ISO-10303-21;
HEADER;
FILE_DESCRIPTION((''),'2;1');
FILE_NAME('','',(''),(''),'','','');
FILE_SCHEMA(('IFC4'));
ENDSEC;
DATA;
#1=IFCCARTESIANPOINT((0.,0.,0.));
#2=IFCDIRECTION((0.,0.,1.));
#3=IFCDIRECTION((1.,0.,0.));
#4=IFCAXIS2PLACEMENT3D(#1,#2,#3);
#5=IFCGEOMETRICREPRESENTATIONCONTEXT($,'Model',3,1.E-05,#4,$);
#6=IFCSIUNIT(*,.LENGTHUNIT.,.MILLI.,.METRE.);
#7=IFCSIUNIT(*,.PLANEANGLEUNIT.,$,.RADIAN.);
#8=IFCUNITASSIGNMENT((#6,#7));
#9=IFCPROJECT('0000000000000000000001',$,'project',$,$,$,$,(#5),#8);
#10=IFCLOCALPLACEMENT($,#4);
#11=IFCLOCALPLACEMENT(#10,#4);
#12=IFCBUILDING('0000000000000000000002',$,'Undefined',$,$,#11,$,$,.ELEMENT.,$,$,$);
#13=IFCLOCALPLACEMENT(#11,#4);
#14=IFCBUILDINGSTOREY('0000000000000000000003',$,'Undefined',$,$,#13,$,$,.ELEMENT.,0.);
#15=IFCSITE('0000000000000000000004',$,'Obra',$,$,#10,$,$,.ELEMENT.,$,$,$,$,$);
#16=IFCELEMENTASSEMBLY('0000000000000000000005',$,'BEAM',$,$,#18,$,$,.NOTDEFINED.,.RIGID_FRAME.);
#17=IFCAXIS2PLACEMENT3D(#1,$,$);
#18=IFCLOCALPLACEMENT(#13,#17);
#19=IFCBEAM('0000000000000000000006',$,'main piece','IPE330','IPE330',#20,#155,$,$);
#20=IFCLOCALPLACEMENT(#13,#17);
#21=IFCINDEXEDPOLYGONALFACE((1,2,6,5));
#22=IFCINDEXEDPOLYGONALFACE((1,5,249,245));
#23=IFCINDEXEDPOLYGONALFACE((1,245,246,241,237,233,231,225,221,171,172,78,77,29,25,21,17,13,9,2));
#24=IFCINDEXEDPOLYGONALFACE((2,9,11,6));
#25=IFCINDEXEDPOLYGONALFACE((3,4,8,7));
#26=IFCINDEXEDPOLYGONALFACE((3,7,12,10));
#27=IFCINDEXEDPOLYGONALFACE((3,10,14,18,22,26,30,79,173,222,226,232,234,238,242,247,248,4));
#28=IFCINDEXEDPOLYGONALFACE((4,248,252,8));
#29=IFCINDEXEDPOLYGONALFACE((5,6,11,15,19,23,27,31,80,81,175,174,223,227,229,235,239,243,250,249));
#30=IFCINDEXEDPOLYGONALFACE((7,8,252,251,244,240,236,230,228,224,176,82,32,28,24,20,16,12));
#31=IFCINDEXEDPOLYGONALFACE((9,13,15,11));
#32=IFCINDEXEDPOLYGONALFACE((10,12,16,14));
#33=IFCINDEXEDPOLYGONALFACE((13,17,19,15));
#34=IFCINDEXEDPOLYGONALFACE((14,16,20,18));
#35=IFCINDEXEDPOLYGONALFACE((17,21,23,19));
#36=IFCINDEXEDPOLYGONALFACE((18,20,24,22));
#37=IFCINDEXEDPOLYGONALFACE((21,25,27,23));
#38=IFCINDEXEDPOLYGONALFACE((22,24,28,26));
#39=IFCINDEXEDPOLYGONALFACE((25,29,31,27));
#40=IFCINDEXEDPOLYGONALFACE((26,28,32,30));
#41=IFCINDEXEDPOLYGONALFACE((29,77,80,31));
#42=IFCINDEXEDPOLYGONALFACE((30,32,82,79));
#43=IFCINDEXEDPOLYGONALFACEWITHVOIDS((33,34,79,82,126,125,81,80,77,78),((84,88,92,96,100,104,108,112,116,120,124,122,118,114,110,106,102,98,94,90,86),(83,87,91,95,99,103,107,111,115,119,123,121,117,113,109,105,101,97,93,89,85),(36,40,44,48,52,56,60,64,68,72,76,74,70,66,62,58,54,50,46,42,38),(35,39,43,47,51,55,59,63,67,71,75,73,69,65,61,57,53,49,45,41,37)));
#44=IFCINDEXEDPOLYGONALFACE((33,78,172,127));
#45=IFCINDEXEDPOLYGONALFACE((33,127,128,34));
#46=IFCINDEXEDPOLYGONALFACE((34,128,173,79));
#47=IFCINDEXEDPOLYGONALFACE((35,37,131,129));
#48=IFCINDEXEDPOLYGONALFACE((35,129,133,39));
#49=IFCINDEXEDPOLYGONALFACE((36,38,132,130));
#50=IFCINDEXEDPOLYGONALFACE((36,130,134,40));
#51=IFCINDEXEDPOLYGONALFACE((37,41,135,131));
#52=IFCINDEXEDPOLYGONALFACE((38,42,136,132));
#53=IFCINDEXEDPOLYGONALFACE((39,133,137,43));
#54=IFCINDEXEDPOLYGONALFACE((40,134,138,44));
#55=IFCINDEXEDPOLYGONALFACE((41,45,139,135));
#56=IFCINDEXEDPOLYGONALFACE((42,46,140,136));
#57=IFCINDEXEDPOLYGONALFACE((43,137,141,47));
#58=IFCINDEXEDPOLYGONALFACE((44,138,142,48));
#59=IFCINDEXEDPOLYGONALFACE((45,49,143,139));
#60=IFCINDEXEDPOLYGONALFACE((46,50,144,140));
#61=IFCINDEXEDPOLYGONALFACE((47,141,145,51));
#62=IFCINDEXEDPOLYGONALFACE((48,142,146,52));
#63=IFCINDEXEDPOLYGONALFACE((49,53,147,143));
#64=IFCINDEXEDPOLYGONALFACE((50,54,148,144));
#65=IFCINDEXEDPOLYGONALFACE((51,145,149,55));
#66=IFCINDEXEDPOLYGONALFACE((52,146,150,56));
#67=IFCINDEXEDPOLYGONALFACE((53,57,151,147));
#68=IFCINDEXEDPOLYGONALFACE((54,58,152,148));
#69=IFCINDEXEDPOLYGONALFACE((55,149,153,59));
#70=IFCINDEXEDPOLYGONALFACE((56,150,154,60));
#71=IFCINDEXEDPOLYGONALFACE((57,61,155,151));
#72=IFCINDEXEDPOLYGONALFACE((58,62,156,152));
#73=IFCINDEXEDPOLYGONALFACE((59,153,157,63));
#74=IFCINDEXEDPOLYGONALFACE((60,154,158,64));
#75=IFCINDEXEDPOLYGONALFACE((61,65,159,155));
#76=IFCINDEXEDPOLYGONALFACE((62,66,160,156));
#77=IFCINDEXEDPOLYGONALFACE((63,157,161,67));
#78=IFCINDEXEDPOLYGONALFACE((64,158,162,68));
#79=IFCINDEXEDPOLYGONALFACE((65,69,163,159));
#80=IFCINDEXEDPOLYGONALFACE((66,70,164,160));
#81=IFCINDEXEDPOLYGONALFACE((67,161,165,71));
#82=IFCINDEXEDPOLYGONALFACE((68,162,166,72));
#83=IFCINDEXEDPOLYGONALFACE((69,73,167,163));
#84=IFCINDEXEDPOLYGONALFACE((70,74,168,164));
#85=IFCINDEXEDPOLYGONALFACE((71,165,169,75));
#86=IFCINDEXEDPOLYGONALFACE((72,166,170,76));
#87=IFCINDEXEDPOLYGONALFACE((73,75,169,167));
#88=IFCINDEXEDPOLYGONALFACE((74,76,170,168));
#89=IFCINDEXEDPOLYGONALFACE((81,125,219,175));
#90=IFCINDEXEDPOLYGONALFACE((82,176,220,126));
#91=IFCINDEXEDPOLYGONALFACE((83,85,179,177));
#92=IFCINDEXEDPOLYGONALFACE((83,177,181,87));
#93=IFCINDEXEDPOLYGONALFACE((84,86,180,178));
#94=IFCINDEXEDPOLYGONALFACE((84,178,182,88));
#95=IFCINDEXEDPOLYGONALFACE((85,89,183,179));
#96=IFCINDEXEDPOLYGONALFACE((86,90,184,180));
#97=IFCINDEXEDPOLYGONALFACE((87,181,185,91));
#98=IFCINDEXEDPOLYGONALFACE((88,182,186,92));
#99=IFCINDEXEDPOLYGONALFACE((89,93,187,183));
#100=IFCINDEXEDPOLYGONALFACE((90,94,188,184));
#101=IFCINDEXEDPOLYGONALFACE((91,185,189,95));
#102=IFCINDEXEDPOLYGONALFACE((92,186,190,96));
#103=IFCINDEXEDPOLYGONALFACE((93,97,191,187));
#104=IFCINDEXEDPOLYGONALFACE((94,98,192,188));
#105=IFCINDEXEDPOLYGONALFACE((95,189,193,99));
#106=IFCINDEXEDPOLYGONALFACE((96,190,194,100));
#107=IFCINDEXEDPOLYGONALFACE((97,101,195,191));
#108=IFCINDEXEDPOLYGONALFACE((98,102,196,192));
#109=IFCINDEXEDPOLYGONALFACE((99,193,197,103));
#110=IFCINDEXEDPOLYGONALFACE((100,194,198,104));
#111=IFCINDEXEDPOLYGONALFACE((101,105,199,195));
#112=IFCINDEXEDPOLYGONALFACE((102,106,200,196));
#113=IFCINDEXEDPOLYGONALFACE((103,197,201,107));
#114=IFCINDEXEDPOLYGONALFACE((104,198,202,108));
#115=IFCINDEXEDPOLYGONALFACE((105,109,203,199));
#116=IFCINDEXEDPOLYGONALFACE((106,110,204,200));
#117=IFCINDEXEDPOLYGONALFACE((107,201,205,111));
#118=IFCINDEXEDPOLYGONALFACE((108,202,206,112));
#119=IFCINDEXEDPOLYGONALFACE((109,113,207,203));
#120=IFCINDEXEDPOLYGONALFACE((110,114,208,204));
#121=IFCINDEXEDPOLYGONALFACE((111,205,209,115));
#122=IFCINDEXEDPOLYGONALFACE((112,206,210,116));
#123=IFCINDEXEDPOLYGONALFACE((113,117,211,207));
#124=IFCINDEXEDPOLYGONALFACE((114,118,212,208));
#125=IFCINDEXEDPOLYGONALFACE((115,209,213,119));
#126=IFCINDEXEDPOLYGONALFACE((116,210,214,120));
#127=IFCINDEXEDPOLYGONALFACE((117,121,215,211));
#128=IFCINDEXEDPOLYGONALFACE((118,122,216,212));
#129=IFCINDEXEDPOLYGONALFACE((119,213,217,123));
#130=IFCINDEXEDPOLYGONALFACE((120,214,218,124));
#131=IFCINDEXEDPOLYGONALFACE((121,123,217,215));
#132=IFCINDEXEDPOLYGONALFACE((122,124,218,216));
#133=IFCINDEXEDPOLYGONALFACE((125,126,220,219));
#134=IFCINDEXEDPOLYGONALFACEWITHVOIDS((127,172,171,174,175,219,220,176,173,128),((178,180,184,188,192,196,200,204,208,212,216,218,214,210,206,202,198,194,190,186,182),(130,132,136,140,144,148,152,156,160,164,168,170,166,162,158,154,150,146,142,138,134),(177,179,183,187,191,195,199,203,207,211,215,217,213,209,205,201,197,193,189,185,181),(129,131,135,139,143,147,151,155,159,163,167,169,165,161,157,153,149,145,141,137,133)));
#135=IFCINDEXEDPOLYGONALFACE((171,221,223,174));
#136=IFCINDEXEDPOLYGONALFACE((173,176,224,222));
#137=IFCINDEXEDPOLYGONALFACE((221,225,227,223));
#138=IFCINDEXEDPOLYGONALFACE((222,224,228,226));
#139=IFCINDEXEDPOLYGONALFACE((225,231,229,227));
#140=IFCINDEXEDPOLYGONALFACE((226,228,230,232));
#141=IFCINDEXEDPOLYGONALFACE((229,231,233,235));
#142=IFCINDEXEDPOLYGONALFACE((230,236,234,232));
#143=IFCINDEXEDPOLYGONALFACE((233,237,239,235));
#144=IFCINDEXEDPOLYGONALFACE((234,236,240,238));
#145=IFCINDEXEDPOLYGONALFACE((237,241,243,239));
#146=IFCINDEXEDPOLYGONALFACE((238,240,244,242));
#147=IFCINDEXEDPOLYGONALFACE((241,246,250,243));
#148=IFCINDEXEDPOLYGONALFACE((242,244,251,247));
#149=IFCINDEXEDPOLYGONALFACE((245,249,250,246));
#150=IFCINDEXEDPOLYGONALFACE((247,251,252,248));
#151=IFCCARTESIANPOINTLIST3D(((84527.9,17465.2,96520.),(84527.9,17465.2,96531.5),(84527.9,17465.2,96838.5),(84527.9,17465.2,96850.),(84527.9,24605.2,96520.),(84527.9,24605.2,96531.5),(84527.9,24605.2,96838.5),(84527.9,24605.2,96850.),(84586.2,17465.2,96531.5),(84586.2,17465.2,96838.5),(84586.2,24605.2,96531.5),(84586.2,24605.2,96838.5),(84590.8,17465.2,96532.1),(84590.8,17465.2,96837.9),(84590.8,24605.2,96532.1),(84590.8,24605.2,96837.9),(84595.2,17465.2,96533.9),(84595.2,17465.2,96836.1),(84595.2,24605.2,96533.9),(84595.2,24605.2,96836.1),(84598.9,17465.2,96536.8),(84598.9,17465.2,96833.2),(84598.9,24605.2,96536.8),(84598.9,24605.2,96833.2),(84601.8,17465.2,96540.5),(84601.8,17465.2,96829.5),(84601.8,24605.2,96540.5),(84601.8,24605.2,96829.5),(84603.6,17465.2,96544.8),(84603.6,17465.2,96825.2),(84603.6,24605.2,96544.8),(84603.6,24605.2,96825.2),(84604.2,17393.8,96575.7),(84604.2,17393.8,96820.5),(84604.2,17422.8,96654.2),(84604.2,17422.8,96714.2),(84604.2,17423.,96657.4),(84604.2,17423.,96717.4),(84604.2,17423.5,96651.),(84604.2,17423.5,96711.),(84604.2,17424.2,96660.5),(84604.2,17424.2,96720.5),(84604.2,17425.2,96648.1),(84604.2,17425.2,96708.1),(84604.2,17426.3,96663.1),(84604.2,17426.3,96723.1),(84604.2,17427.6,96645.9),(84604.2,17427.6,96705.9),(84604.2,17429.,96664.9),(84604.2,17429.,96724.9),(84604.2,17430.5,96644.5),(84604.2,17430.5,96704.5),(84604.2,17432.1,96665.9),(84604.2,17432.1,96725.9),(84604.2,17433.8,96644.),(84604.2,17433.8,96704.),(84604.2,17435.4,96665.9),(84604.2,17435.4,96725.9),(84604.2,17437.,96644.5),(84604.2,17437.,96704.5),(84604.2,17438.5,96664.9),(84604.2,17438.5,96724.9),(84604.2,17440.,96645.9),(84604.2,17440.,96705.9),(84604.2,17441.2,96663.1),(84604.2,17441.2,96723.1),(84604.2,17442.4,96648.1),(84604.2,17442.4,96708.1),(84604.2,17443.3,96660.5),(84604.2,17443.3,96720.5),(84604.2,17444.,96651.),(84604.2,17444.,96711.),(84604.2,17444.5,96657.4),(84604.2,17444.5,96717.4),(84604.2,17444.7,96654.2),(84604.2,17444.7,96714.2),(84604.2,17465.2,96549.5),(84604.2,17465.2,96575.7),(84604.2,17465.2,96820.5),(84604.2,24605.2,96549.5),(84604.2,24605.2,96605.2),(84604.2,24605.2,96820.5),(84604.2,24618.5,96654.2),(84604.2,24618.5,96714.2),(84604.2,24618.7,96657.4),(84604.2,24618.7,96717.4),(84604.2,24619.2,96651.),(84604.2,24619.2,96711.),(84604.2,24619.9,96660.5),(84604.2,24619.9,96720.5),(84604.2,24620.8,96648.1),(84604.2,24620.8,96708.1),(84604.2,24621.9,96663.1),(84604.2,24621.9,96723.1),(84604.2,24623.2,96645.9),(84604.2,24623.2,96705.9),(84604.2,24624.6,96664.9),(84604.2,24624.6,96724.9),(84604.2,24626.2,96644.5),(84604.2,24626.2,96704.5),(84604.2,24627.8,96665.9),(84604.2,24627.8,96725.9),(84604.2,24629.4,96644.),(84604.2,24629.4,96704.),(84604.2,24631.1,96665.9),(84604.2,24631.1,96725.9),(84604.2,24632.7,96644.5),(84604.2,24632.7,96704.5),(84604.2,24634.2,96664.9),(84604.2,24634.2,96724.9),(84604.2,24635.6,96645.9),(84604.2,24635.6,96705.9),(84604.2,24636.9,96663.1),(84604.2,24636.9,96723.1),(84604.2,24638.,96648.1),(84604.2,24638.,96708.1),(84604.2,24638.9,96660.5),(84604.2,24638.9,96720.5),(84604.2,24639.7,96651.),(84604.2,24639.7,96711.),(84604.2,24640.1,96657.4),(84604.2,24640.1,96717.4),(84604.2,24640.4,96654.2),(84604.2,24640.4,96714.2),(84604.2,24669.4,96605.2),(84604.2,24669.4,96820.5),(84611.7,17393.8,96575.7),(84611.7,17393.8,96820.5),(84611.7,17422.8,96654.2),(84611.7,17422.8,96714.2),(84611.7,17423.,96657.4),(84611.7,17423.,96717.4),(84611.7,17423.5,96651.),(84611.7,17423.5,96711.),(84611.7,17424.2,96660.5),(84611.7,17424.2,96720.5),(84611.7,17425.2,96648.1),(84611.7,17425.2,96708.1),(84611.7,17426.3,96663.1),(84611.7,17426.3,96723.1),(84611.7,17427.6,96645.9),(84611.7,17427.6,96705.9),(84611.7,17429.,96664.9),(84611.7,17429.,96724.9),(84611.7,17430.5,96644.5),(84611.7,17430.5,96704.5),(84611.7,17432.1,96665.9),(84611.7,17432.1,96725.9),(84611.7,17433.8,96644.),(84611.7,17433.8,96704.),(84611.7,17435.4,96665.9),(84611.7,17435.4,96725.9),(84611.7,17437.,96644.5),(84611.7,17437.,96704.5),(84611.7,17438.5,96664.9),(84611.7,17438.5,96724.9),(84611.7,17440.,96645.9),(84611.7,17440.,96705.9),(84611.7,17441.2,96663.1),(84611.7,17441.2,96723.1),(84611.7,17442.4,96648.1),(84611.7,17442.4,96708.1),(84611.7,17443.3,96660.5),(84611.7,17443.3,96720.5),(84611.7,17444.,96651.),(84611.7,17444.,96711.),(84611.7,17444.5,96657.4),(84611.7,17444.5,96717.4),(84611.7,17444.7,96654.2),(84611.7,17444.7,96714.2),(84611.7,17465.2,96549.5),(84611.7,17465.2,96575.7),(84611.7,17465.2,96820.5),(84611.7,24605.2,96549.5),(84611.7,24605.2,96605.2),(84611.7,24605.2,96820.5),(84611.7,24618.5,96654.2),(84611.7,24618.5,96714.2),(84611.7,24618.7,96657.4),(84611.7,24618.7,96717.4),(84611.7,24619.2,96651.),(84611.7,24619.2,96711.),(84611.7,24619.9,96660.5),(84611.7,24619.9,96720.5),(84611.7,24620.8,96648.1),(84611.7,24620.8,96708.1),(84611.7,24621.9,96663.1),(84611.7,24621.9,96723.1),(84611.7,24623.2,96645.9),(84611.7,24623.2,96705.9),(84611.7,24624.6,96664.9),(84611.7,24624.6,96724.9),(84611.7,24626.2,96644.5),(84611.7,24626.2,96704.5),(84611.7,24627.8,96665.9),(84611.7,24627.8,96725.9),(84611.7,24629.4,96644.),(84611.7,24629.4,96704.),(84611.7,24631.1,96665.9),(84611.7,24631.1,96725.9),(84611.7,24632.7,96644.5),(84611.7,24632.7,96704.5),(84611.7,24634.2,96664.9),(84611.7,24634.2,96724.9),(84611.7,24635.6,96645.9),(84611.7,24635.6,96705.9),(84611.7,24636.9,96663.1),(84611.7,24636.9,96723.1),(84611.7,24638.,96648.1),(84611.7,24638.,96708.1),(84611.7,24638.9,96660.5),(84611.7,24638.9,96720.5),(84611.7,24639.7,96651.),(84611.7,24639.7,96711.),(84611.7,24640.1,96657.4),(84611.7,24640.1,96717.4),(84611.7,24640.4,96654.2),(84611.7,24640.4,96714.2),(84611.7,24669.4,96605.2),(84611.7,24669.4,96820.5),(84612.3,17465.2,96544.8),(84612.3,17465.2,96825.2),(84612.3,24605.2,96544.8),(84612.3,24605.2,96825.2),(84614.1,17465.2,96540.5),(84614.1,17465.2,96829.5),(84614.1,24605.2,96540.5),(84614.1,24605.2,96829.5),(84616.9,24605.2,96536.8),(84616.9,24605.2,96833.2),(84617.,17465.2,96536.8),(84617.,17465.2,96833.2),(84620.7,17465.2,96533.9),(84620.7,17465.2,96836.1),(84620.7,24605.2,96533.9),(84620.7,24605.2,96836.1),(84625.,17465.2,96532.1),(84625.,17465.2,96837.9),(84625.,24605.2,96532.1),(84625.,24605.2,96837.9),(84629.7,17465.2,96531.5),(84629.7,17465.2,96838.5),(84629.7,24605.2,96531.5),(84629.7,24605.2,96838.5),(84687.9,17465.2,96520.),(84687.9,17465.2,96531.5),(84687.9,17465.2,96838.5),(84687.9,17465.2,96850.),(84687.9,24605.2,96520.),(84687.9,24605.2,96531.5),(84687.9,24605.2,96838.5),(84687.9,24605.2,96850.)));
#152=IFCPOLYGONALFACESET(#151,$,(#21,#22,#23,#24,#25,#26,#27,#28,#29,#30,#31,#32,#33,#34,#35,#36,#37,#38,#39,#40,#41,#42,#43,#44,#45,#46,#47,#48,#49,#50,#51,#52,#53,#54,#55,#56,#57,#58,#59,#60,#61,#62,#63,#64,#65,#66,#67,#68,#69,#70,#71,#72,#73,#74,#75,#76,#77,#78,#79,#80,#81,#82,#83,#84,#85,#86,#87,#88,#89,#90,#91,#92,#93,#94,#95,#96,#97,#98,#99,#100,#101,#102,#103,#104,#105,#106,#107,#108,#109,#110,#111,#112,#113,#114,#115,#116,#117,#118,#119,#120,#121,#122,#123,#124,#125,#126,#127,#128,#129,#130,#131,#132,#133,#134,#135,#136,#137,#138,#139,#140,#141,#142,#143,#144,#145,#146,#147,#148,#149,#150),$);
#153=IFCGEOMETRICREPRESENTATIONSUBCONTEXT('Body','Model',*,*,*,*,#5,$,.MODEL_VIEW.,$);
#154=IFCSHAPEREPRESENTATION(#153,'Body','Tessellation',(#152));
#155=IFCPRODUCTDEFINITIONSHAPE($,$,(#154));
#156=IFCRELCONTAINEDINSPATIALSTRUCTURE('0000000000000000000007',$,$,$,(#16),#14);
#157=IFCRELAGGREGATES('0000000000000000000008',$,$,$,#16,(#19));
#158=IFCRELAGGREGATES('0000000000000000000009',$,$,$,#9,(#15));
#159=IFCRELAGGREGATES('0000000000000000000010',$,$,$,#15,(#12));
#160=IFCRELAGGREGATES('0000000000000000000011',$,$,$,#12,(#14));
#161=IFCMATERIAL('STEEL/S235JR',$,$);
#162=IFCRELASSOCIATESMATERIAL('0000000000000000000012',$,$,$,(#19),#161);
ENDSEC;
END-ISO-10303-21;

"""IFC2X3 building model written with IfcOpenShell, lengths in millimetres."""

from ifc_helpers import new_model, si_unit, frame, origin_with_axes, origin_2d_with_axis, place, context, subcontext, project, spatial, rectangle, circle, i_section, extrude, clip, halfspace, source, transform, mapped, material, element, aggregate, save


model = new_model("IFC2X3")

# Units and contexts
model_context = context("Model", 3, precision=1e-05, world=origin_with_axes())
body_context = subcontext(model_context, "Body", "Model", "MODEL_VIEW")
ifc_project = project(units=[si_unit("LENGTHUNIT", "METRE", prefix="MILLI"), si_unit("PLANEANGLEUNIT", "RADIAN")], contexts=[model_context])

# Site, building, storey
site_placement = place(None, origin_with_axes())
site = spatial("IfcSite", under=ifc_project, at=site_placement, Name="Obra", CompositionType="ELEMENT")
building_placement = place(site_placement, origin_with_axes())
building = spatial("IfcBuilding", under=site, at=building_placement, Name="Undefined", CompositionType="ELEMENT")
storey_placement = place(building_placement, origin_with_axes())
storey = spatial("IfcBuildingStorey", under=building, at=storey_placement, Name="Undefined", CompositionType="ELEMENT", Elevation=0.0)

# Element assembly, beam, openings
assembly_1_placement = place(storey_placement, origin_with_axes())
assembly_1 = element("IfcElementAssembly", 1, at=assembly_1_placement, inside=storey, Name="BEAM", AssemblyPlace="NOTDEFINED", PredefinedType="RIGID_FRAME")
ifc_material = material(Name="STEEL/S235JR")
beam_1_placement = place(assembly_1_placement, frame((84607.9, 17475.2, 96685.0), z_axis=(0.0, 0.0, 1.0), x_axis=(-0.000002, 1.0, 0.0)))
beam_1 = element("IfcBeam", 2, at=beam_1_placement, material=ifc_material, Name="main piece", Description="IPE330", ObjectType="IPE330", context=body_context, shape_type="Clipping", body=[
    clip(clip(extrude(i_section(OverallWidth=160.0, OverallDepth=330.0, WebThickness=7.5, FlangeThickness=11.5, FilletRadius=18.0, at=origin_2d_with_axis()), frame((7194.2, 0.0, 0.0), z_axis=(-1.0, 0.0, 0.0), x_axis=(0.0, -1.0, 0.0)), (0.0, 0.0, 1.0), 7275.7), halfspace(frame((7194.2, 0.0, -265.0), z_axis=(-1.0, 0.0, 0.0), x_axis=(0.0, 1.0, 0.0)), True)), halfspace(frame((-81.5, 0.0, -265.0), z_axis=(1.0, -0.000002, 0.0), x_axis=(-0.000001, -1.0, 0.0)), True)),
])
opening_1_placement = place(assembly_1_placement, frame((84607.9, 17475.2, 96685.0), z_axis=(0.0, 0.0, 1.0), x_axis=(-0.000002, 1.0, 0.0)))
element("IfcOpeningElement", 3, at=opening_1_placement, cuts=beam_1, ObjectType="Recess", context=body_context, shape_type="SweptSolid", body=[
    extrude(rectangle(XDim=76.2, YDim=86.2, at=origin_2d_with_axis()), frame((7168.1, 81.0, -122.9), z_axis=(0.0, -1.0, 0.0), x_axis=(1.0, 0.0, 0.0)), (0.0, 0.0, 1.0), 162.0),
])
opening_2_placement = place(assembly_1_placement, frame((84607.9, 17475.2, 96685.0), z_axis=(0.0, 0.0, 1.0), x_axis=(-0.000002, 1.0, 0.0)))
element("IfcOpeningElement", 4, at=opening_2_placement, cuts=beam_1, ObjectType="Recess", context=body_context, shape_type="SweptSolid", body=[
    extrude(rectangle(XDim=30.5, YDim=76.2, at=origin_2d_with_axis()), frame((7168.1, 81.0, 150.7), z_axis=(0.0, -1.0, 0.0), x_axis=(0.0, 0.0, -1.0)), (0.0, 0.0, 1.0), 162.0),
])
opening_3_placement = place(assembly_1_placement, frame((84607.9, 17475.2, 96685.0), z_axis=(0.0, 0.0, 1.0), x_axis=(-0.000002, 1.0, 0.0)))
element("IfcOpeningElement", 5, at=opening_3_placement, cuts=beam_1, ObjectType="Recess", context=body_context, shape_type="SweptSolid", body=[
    extrude(rectangle(XDim=56.7, YDim=83.5, at=origin_2d_with_axis()), frame((-51.7, -81.0, -137.7), z_axis=(0.000002, 1.0, 0.0), x_axis=(0.0, 0.0, -1.0)), (0.0, 0.0, 1.0), 162.0),
])
opening_4_placement = place(assembly_1_placement, frame((84607.9, 17475.2, 96685.0), z_axis=(0.0, 0.0, 1.0), x_axis=(-0.000002, 1.0, 0.0)))
element("IfcOpeningElement", 6, at=opening_4_placement, cuts=beam_1, ObjectType="Recess", context=body_context, shape_type="SweptSolid", body=[
    extrude(rectangle(XDim=30.5, YDim=83.5, at=origin_2d_with_axis()), frame((-51.7, -81.0, 150.7), z_axis=(0.000002, 1.0, 0.0), x_axis=(0.0, 0.0, -1.0)), (0.0, 0.0, 1.0), 162.0),
])
shared_shape_1 = source(origin_with_axes(), body_context, "Body", "SweptSolid", [
    extrude(circle(Radius=11.0, at=origin_2d_with_axis()), frame((0.0, -3.9, 0.0), z_axis=(0.0, 1.0, 0.0), x_axis=(1.0, 0.0, 0.0)), (0.0, 0.0, 1.0), 7.7),
])
opening_5_placement = place(assembly_1_placement, frame((84607.9, 24669.4, 96850.0), z_axis=(0.000002, -1.0, 0.0), x_axis=(0.0, 0.0, -1.0)))
element("IfcOpeningElement", 7, at=opening_5_placement, cuts=beam_1, ObjectType="Opening", context=body_context, shape_type="MappedRepresentation", body=[
    mapped(shared_shape_1, transform((135.0, 0.0, 40.0))),
    mapped(shared_shape_1, transform((195.0, 0.0, 40.0))),
])
opening_6_placement = place(assembly_1_placement, frame((84607.9, 17393.8, 96850.0), z_axis=(0.0, 1.0, 0.0), x_axis=(0.0, 0.0, -1.0)))
element("IfcOpeningElement", 8, at=opening_6_placement, cuts=beam_1, ObjectType="Opening", context=body_context, shape_type="MappedRepresentation", body=[
    mapped(shared_shape_1, transform((135.0, 0.0, 40.0))),
    mapped(shared_shape_1, transform((195.0, 0.0, 40.0))),
])
aggregate(assembly_1, [beam_1])

save(model, "model.ifc")
